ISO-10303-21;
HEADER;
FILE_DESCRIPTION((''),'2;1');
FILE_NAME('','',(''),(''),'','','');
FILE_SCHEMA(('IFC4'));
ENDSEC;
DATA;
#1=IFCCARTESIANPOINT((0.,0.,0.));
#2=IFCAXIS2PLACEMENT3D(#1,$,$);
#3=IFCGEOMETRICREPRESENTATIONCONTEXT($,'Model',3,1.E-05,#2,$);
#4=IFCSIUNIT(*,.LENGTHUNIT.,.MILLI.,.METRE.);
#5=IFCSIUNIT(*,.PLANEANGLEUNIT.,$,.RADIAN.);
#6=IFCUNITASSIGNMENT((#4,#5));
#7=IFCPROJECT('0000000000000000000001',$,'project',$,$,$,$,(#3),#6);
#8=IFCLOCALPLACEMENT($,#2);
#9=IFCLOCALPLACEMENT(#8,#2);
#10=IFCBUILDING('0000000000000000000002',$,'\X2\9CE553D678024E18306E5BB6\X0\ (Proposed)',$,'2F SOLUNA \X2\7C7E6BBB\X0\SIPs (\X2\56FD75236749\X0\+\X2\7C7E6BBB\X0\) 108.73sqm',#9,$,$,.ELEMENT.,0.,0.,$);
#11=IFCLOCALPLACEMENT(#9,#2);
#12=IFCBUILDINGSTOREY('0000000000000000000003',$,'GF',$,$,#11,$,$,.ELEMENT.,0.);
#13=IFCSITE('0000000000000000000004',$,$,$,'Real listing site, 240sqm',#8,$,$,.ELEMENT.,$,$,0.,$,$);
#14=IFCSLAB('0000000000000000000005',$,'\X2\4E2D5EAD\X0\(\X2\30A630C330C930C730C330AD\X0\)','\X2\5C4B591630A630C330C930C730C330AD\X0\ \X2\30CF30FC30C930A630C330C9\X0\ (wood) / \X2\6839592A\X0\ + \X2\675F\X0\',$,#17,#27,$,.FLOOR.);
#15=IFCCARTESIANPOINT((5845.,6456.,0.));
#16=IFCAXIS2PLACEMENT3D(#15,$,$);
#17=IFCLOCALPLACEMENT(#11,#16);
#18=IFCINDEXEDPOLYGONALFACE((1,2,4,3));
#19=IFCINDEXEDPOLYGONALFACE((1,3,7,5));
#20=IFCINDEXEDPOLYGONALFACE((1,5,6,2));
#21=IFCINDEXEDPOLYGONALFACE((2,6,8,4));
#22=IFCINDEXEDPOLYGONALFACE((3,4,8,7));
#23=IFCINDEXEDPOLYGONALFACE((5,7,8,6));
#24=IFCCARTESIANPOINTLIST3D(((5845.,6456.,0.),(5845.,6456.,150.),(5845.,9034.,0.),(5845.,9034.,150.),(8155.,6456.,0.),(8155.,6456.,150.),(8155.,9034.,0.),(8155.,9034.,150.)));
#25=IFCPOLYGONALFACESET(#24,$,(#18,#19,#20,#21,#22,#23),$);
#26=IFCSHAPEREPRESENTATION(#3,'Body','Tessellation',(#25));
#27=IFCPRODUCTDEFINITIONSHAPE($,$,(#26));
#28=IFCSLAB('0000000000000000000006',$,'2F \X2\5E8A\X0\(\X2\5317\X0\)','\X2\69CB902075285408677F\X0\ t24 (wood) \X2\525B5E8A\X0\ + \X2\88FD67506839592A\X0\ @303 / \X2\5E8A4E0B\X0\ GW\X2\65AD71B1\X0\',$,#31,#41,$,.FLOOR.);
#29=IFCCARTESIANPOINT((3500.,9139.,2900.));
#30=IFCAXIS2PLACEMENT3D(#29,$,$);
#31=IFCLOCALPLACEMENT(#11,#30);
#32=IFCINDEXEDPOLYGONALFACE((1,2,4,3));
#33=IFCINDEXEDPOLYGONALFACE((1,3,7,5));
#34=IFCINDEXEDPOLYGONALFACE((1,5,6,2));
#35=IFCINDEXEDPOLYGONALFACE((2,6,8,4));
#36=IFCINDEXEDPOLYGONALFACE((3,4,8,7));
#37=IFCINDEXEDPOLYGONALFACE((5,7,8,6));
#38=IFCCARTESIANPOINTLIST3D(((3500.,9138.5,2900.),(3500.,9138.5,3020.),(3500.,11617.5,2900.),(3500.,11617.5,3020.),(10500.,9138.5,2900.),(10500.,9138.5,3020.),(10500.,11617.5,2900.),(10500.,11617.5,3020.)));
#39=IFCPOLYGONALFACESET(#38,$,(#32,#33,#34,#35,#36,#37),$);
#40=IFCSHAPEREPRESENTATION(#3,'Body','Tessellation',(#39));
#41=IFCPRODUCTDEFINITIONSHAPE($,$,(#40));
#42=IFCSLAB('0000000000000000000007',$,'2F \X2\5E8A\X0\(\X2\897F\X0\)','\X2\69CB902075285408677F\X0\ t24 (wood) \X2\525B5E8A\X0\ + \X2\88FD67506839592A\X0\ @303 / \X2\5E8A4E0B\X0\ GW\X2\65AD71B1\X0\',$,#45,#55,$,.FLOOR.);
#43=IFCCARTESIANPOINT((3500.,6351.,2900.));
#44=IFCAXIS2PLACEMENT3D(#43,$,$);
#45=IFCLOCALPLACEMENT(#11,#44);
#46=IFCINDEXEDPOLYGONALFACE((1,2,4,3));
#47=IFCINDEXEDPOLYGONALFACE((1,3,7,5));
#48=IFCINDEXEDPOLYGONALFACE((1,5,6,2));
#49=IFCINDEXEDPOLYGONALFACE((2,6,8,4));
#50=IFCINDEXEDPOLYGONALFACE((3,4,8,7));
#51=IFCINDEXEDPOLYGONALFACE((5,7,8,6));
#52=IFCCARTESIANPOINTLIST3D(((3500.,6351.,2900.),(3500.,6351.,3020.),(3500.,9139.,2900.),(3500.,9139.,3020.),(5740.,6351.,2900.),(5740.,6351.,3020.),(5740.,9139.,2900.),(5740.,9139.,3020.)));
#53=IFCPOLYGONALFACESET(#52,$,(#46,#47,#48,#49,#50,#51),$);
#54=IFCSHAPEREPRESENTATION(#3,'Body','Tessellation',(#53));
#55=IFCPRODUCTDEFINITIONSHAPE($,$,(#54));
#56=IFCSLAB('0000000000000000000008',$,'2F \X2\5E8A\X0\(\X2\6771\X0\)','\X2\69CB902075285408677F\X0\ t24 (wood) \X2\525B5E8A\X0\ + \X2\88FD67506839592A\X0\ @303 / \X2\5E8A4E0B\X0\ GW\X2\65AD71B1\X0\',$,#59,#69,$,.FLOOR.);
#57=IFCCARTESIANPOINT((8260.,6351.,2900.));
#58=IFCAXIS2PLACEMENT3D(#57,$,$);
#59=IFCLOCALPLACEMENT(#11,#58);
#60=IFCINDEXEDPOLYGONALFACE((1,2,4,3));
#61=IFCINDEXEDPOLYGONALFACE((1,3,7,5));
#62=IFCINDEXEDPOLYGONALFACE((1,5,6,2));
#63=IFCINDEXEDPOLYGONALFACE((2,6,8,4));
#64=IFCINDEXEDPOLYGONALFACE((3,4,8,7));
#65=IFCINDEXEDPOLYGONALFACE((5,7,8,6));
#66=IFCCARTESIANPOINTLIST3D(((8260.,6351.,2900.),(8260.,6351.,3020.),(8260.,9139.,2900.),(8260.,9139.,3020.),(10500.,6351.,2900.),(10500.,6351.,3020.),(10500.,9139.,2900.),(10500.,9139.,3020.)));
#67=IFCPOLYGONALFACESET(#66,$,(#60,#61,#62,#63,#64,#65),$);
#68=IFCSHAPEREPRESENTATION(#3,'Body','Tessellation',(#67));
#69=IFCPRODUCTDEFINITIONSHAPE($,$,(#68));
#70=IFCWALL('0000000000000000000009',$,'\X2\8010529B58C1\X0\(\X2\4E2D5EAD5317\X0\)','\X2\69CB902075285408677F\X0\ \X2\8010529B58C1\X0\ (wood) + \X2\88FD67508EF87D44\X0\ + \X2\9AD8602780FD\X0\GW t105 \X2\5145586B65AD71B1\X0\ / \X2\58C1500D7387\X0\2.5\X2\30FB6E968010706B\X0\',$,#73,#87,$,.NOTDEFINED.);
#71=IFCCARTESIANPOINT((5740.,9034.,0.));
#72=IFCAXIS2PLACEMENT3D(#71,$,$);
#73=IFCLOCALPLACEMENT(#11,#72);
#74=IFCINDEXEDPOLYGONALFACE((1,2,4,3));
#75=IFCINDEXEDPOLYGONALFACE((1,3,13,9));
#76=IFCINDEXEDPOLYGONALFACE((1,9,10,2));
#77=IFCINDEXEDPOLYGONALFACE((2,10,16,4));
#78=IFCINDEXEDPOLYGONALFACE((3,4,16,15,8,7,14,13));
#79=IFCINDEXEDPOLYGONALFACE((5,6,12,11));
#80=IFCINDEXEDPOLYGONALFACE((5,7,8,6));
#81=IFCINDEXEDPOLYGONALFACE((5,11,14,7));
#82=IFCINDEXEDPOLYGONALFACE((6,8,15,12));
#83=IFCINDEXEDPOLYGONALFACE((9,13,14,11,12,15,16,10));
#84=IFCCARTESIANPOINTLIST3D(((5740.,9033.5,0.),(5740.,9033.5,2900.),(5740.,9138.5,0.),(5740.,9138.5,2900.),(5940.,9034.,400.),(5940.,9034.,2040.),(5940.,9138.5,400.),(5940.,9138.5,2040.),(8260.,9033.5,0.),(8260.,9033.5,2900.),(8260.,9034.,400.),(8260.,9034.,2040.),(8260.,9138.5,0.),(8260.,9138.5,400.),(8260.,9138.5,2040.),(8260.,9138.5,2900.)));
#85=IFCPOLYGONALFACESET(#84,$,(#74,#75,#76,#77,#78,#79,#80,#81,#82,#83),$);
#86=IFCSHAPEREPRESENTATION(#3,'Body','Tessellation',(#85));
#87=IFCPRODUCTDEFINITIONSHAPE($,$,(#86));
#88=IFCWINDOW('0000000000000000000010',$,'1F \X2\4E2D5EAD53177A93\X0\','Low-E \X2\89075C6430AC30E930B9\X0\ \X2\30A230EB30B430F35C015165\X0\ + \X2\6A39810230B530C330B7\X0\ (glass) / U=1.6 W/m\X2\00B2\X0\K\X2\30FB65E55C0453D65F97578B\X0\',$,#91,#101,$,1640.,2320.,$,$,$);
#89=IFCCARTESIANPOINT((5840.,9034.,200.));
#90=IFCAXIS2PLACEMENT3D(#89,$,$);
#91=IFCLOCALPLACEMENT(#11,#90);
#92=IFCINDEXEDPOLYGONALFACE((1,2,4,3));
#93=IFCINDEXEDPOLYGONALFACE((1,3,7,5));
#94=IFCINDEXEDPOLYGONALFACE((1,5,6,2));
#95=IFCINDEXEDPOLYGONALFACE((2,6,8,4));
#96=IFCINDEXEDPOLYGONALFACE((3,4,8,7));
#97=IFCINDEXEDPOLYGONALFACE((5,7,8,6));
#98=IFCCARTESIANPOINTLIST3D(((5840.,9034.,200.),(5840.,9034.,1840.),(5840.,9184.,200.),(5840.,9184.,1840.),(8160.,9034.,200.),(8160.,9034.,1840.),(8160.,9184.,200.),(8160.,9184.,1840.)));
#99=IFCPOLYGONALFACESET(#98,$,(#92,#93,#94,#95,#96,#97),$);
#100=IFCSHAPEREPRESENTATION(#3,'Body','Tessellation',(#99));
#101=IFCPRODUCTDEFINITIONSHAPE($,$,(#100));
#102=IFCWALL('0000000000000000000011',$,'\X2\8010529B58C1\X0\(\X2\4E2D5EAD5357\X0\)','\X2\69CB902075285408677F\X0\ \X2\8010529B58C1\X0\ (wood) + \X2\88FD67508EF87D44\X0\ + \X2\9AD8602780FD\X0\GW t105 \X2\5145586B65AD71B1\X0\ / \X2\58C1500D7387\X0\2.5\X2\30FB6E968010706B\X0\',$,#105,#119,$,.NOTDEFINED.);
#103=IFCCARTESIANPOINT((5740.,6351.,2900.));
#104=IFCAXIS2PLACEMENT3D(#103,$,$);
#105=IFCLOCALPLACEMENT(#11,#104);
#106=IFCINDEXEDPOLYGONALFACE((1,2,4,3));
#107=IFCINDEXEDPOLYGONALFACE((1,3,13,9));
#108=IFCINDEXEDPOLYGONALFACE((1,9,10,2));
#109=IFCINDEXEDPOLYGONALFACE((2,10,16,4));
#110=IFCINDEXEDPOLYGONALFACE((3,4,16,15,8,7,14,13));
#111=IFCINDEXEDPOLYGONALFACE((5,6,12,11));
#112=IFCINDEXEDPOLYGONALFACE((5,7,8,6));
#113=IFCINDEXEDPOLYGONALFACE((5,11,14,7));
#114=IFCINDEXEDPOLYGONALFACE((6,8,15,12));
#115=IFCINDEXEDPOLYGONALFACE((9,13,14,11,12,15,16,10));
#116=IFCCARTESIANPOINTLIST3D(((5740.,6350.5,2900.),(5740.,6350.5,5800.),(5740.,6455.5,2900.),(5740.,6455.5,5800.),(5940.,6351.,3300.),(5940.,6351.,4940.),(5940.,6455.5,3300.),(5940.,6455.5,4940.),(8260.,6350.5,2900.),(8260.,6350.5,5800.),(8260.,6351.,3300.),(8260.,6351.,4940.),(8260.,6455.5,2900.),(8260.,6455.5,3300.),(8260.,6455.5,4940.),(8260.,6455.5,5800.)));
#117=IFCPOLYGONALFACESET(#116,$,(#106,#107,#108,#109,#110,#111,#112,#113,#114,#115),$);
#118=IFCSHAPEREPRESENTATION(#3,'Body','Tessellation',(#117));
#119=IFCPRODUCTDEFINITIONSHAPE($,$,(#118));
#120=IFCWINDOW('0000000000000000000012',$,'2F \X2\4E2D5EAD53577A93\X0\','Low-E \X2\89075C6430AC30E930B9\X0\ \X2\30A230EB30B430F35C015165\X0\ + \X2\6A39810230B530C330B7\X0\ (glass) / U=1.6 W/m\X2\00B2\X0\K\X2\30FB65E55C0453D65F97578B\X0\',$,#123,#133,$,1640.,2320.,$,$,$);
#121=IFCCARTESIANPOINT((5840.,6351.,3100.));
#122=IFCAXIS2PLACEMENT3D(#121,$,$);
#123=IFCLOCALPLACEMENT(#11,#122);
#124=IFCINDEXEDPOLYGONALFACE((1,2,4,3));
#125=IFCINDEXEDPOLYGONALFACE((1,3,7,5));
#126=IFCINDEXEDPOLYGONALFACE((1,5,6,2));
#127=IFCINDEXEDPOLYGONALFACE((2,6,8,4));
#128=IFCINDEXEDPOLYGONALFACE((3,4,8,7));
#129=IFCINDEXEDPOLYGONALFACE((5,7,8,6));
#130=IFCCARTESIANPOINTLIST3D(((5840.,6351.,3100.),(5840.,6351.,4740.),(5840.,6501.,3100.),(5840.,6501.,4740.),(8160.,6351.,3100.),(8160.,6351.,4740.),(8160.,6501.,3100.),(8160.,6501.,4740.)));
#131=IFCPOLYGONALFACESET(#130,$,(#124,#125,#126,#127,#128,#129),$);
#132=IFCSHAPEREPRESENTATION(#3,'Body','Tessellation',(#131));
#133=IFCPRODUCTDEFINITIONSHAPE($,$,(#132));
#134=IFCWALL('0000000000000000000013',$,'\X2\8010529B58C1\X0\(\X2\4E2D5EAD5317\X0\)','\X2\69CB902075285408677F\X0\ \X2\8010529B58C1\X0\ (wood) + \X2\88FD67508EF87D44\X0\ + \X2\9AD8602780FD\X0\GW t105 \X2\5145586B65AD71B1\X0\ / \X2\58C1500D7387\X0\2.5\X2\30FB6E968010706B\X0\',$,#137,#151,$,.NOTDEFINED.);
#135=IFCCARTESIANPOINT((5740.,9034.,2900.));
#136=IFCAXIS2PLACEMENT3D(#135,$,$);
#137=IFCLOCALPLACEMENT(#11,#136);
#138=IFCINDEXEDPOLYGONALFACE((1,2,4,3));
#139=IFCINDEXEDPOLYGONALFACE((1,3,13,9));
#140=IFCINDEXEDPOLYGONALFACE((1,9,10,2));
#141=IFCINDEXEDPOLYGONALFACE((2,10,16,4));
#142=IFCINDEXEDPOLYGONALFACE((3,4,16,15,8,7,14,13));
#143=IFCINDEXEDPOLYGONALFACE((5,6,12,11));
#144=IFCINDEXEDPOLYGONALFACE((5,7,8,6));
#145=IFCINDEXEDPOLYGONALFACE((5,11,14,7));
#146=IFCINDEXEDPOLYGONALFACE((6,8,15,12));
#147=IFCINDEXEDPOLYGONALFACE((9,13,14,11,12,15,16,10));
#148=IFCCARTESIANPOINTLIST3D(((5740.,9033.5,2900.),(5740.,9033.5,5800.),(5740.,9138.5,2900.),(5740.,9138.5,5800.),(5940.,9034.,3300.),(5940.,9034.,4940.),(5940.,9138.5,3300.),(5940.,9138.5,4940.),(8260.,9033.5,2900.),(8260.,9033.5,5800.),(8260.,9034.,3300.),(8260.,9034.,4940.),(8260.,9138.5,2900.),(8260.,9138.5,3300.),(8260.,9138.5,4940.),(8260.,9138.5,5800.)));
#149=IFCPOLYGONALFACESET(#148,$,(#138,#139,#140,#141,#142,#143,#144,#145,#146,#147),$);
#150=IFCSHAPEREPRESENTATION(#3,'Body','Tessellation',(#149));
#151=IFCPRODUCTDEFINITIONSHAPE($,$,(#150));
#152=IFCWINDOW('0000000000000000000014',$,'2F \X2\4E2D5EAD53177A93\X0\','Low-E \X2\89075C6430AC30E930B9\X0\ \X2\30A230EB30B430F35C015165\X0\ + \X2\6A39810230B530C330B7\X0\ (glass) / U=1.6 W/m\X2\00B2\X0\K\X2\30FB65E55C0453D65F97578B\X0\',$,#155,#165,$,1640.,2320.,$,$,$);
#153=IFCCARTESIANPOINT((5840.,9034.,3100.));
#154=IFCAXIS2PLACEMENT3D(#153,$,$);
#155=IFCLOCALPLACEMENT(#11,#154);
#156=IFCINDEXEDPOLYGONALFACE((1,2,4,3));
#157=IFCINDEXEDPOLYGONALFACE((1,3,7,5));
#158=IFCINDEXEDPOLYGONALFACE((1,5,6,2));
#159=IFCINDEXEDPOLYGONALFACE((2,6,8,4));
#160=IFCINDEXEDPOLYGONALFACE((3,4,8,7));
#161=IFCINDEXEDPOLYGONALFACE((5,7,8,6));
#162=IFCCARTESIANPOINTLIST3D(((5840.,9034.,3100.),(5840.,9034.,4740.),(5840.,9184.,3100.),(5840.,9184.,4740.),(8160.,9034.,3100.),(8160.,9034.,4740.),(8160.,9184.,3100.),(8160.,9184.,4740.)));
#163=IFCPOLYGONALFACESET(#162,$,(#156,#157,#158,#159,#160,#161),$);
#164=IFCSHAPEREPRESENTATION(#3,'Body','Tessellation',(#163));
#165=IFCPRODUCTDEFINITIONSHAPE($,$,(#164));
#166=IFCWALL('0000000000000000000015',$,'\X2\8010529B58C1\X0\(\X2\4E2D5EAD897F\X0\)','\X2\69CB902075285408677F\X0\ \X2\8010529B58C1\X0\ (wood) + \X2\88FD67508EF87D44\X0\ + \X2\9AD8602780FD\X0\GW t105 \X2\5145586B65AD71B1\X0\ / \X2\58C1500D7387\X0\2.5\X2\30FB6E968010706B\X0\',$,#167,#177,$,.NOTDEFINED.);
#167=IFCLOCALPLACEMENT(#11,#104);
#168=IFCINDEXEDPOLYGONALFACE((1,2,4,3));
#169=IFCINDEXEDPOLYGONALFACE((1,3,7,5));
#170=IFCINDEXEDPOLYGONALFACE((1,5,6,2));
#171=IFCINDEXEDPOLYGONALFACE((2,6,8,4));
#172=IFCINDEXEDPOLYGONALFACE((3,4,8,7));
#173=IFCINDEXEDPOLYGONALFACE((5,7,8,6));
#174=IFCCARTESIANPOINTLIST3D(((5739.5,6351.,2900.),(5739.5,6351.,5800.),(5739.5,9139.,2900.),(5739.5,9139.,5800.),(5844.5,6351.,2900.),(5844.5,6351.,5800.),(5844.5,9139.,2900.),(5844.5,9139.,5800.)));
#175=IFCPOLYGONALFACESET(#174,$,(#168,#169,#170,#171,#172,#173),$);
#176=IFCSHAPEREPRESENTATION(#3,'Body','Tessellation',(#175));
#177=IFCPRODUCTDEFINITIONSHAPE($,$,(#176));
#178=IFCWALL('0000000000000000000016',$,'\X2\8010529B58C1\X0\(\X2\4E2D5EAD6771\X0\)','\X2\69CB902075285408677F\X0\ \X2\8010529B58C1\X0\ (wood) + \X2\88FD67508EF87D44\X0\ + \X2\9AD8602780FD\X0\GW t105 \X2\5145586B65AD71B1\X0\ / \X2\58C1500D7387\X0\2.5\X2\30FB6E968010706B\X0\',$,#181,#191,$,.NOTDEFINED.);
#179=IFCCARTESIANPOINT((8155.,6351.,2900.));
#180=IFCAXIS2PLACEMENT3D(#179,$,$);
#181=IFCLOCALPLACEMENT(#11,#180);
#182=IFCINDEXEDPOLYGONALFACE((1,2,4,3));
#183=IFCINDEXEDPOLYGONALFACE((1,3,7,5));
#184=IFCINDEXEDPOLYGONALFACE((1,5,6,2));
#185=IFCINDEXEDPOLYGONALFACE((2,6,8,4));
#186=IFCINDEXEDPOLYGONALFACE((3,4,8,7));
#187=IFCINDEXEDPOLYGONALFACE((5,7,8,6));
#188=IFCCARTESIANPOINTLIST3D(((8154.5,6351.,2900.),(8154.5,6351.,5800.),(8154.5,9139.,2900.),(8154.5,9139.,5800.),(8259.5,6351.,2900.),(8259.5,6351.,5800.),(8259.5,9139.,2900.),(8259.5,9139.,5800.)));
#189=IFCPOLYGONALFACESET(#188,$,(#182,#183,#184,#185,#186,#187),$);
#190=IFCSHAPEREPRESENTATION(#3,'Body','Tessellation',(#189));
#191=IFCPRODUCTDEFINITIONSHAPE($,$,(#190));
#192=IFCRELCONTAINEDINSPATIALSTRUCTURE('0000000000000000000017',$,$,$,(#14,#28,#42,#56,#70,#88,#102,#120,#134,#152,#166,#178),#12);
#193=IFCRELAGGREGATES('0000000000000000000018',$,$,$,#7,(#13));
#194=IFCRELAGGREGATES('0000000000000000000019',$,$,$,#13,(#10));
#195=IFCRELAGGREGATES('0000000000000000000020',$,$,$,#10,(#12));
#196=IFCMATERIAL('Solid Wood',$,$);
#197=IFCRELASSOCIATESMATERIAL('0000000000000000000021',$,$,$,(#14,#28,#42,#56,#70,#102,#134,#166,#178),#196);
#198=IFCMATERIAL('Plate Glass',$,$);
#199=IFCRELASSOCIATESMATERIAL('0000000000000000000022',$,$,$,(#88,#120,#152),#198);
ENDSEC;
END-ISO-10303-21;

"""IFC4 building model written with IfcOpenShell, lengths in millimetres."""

from ifc_helpers import new_model, si_unit, frame, frame_2d, origin, place, context, project, spatial, rectangle, extrude, material, element, fill, save


model = new_model("IFC4")

# Units and contexts
model_context = context("Model", 3, precision=1e-05, world=origin())
ifc_project = project(units=[si_unit("LENGTHUNIT", "METRE", prefix="MILLI"), si_unit("PLANEANGLEUNIT", "RADIAN")], contexts=[model_context])

# Site, building, storey
site_placement = place(None, origin())
site = spatial("IfcSite", under=ifc_project, at=site_placement, ObjectType="Real listing site, 240sqm", CompositionType="ELEMENT", RefElevation=0.0)
building_placement = place(site_placement, origin())
building = spatial("IfcBuilding", under=site, at=building_placement, Name="鳥取砂丘の家 (Proposed)", ObjectType="2F SOLUNA 籾殻SIPs (国産杉+籾殻) 108.73sqm", CompositionType="ELEMENT", ElevationOfRefHeight=0.0, ElevationOfTerrain=0.0)
storey_placement = place(building_placement, origin())
storey = spatial("IfcBuildingStorey", under=building, at=storey_placement, Name="GF", CompositionType="ELEMENT", Elevation=0.0)

# Slabs
ifc_material_1 = material(Name="Solid Wood")
slab_1_placement = place(storey_placement, frame((5845.0, 6456.0, 0.0)))
element("IfcSlab", 1, at=slab_1_placement, inside=storey, material=ifc_material_1, Name="中庭(ウッドデッキ)", Description="屋外ウッドデッキ ハードウッド (wood) / 根太 + 束", PredefinedType="FLOOR", context=model_context, shape_type="SweptSolid", body=[
    extrude(rectangle(XDim=2310.0, YDim=2578.0, at=frame_2d((1155.0, 1289.0))), frame((5845.0, 6456.0, 0.0)), (0.0, 0.0, 1.0), 150.0),
])
slab_2_placement = place(storey_placement, frame((3500.0, 9139.0, 2900.0)))
element("IfcSlab", 2, at=slab_2_placement, inside=storey, material=ifc_material_1, Name="2F 床(北)", Description="構造用合板 t24 (wood) 剛床 + 製材根太 @303 / 床下 GW断熱", PredefinedType="FLOOR", context=model_context, shape_type="SweptSolid", body=[
    extrude(rectangle(XDim=7000.0, YDim=2479.0, at=frame_2d((3500.0, 1239.0))), frame((3500.0, 9139.0, 2900.0)), (0.0, 0.0, 1.0), 120.0),
])
slab_3_placement = place(storey_placement, frame((3500.0, 6351.0, 2900.0)))
element("IfcSlab", 3, at=slab_3_placement, inside=storey, material=ifc_material_1, Name="2F 床(西)", Description="構造用合板 t24 (wood) 剛床 + 製材根太 @303 / 床下 GW断熱", PredefinedType="FLOOR", context=model_context, shape_type="SweptSolid", body=[
    extrude(rectangle(XDim=2240.0, YDim=2788.0, at=frame_2d((1120.0, 1394.0))), frame((3500.0, 6351.0, 2900.0)), (0.0, 0.0, 1.0), 120.0),
])
slab_4_placement = place(storey_placement, frame((8260.0, 6351.0, 2900.0)))
element("IfcSlab", 4, at=slab_4_placement, inside=storey, material=ifc_material_1, Name="2F 床(東)", Description="構造用合板 t24 (wood) 剛床 + 製材根太 @303 / 床下 GW断熱", PredefinedType="FLOOR", context=model_context, shape_type="SweptSolid", body=[
    extrude(rectangle(XDim=2240.0, YDim=2788.0, at=frame_2d((1120.0, 1394.0))), frame((8260.0, 6351.0, 2900.0)), (0.0, 0.0, 1.0), 120.0),
])

# Wall, opening, window
wall_1_placement = place(storey_placement, frame((5740.0, 9034.0, 0.0)))
wall_1 = element("IfcWall", 5, at=wall_1_placement, inside=storey, material=ifc_material_1, Name="耐力壁(中庭北)", Description="構造用合板 耐力壁 (wood) + 製材軸組 + 高性能GW t105 充填断熱 / 壁倍率2.5・準耐火", PredefinedType="NOTDEFINED", context=model_context, shape_type="SweptSolid", body=[
    extrude(rectangle(XDim=2520.0, YDim=105.0, at=frame_2d((1260.0, 52.0))), frame((5740.0, 9034.0, 0.0)), (0.0, 0.0, 1.0), 2900.0),
])
opening_1_placement = place(storey_placement, frame((5840.0, 9034.0, 200.0)))
opening_1 = element("IfcOpeningElement", 6, at=opening_1_placement, cuts=wall_1, PredefinedType="NOTDEFINED", context=model_context, shape_type="SweptSolid", body=[
    extrude(rectangle(XDim=2320.0, YDim=150.0, at=frame_2d((1160.0, 75.0))), frame((5840.0, 9034.0, 200.0)), (0.0, 0.0, 1.0), 1640.0),
])
ifc_material_2 = material(Name="Plate Glass")
window_1_placement = place(storey_placement, frame((5840.0, 9034.0, 200.0)))
window_1 = element("IfcWindow", 7, at=window_1_placement, inside=storey, material=ifc_material_2, Name="1F 中庭北窓", Description="Low-E 複層ガラス アルゴン封入 + 樹脂サッシ (glass) / U=1.6 W/m²K・日射取得型", OverallHeight=1640.0, OverallWidth=2320.0, context=model_context, shape_type="SweptSolid", body=[
    extrude(rectangle(XDim=2320.0, YDim=150.0, at=frame_2d((1160.0, 75.0))), frame((5840.0, 9034.0, 200.0)), (0.0, 0.0, 1.0), 1640.0),
])
fill(opening_1, window_1)

# Walls, openings, windows
wall_2_placement = place(storey_placement, frame((5740.0, 6351.0, 2900.0)))
wall_2 = element("IfcWall", 8, at=wall_2_placement, inside=storey, material=ifc_material_1, Name="耐力壁(中庭南)", Description="構造用合板 耐力壁 (wood) + 製材軸組 + 高性能GW t105 充填断熱 / 壁倍率2.5・準耐火", PredefinedType="NOTDEFINED", context=model_context, shape_type="SweptSolid", body=[
    extrude(rectangle(XDim=2520.0, YDim=105.0, at=frame_2d((1260.0, 52.0))), frame((5740.0, 6351.0, 2900.0)), (0.0, 0.0, 1.0), 2900.0),
])
opening_2_placement = place(storey_placement, frame((5840.0, 6351.0, 3100.0)))
opening_2 = element("IfcOpeningElement", 9, at=opening_2_placement, cuts=wall_2, PredefinedType="NOTDEFINED", context=model_context, shape_type="SweptSolid", body=[
    extrude(rectangle(XDim=2320.0, YDim=150.0, at=frame_2d((1160.0, 75.0))), frame((5840.0, 6351.0, 3100.0)), (0.0, 0.0, 1.0), 1640.0),
])
window_2_placement = place(storey_placement, frame((5840.0, 6351.0, 3100.0)))
window_2 = element("IfcWindow", 10, at=window_2_placement, inside=storey, material=ifc_material_2, Name="2F 中庭南窓", Description="Low-E 複層ガラス アルゴン封入 + 樹脂サッシ (glass) / U=1.6 W/m²K・日射取得型", OverallHeight=1640.0, OverallWidth=2320.0, context=model_context, shape_type="SweptSolid", body=[
    extrude(rectangle(XDim=2320.0, YDim=150.0, at=frame_2d((1160.0, 75.0))), frame((5840.0, 6351.0, 3100.0)), (0.0, 0.0, 1.0), 1640.0),
])
fill(opening_2, window_2)
wall_3_placement = place(storey_placement, frame((5740.0, 9034.0, 2900.0)))
wall_3 = element("IfcWall", 11, at=wall_3_placement, inside=storey, material=ifc_material_1, Name="耐力壁(中庭北)", Description="構造用合板 耐力壁 (wood) + 製材軸組 + 高性能GW t105 充填断熱 / 壁倍率2.5・準耐火", PredefinedType="NOTDEFINED", context=model_context, shape_type="SweptSolid", body=[
    extrude(rectangle(XDim=2520.0, YDim=105.0, at=frame_2d((1260.0, 52.0))), frame((5740.0, 9034.0, 2900.0)), (0.0, 0.0, 1.0), 2900.0),
])
opening_3_placement = place(storey_placement, frame((5840.0, 9034.0, 3100.0)))
opening_3 = element("IfcOpeningElement", 12, at=opening_3_placement, cuts=wall_3, PredefinedType="NOTDEFINED", context=model_context, shape_type="SweptSolid", body=[
    extrude(rectangle(XDim=2320.0, YDim=150.0, at=frame_2d((1160.0, 75.0))), frame((5840.0, 9034.0, 3100.0)), (0.0, 0.0, 1.0), 1640.0),
])
window_3_placement = place(storey_placement, frame((5840.0, 9034.0, 3100.0)))
window_3 = element("IfcWindow", 13, at=window_3_placement, inside=storey, material=ifc_material_2, Name="2F 中庭北窓", Description="Low-E 複層ガラス アルゴン封入 + 樹脂サッシ (glass) / U=1.6 W/m²K・日射取得型", OverallHeight=1640.0, OverallWidth=2320.0, context=model_context, shape_type="SweptSolid", body=[
    extrude(rectangle(XDim=2320.0, YDim=150.0, at=frame_2d((1160.0, 75.0))), frame((5840.0, 9034.0, 3100.0)), (0.0, 0.0, 1.0), 1640.0),
])
fill(opening_3, window_3)

# Walls
wall_4_placement = place(storey_placement, frame((5740.0, 6351.0, 2900.0)))
element("IfcWall", 14, at=wall_4_placement, inside=storey, material=ifc_material_1, Name="耐力壁(中庭西)", Description="構造用合板 耐力壁 (wood) + 製材軸組 + 高性能GW t105 充填断熱 / 壁倍率2.5・準耐火", PredefinedType="NOTDEFINED", context=model_context, shape_type="SweptSolid", body=[
    extrude(rectangle(XDim=105.0, YDim=2788.0, at=frame_2d((52.0, 1394.0))), frame((5740.0, 6351.0, 2900.0)), (0.0, 0.0, 1.0), 2900.0),
])
wall_5_placement = place(storey_placement, frame((8155.0, 6351.0, 2900.0)))
element("IfcWall", 15, at=wall_5_placement, inside=storey, material=ifc_material_1, Name="耐力壁(中庭東)", Description="構造用合板 耐力壁 (wood) + 製材軸組 + 高性能GW t105 充填断熱 / 壁倍率2.5・準耐火", PredefinedType="NOTDEFINED", context=model_context, shape_type="SweptSolid", body=[
    extrude(rectangle(XDim=105.0, YDim=2788.0, at=frame_2d((52.0, 1394.0))), frame((8155.0, 6351.0, 2900.0)), (0.0, 0.0, 1.0), 2900.0),
])

save(model, "model.ifc")
